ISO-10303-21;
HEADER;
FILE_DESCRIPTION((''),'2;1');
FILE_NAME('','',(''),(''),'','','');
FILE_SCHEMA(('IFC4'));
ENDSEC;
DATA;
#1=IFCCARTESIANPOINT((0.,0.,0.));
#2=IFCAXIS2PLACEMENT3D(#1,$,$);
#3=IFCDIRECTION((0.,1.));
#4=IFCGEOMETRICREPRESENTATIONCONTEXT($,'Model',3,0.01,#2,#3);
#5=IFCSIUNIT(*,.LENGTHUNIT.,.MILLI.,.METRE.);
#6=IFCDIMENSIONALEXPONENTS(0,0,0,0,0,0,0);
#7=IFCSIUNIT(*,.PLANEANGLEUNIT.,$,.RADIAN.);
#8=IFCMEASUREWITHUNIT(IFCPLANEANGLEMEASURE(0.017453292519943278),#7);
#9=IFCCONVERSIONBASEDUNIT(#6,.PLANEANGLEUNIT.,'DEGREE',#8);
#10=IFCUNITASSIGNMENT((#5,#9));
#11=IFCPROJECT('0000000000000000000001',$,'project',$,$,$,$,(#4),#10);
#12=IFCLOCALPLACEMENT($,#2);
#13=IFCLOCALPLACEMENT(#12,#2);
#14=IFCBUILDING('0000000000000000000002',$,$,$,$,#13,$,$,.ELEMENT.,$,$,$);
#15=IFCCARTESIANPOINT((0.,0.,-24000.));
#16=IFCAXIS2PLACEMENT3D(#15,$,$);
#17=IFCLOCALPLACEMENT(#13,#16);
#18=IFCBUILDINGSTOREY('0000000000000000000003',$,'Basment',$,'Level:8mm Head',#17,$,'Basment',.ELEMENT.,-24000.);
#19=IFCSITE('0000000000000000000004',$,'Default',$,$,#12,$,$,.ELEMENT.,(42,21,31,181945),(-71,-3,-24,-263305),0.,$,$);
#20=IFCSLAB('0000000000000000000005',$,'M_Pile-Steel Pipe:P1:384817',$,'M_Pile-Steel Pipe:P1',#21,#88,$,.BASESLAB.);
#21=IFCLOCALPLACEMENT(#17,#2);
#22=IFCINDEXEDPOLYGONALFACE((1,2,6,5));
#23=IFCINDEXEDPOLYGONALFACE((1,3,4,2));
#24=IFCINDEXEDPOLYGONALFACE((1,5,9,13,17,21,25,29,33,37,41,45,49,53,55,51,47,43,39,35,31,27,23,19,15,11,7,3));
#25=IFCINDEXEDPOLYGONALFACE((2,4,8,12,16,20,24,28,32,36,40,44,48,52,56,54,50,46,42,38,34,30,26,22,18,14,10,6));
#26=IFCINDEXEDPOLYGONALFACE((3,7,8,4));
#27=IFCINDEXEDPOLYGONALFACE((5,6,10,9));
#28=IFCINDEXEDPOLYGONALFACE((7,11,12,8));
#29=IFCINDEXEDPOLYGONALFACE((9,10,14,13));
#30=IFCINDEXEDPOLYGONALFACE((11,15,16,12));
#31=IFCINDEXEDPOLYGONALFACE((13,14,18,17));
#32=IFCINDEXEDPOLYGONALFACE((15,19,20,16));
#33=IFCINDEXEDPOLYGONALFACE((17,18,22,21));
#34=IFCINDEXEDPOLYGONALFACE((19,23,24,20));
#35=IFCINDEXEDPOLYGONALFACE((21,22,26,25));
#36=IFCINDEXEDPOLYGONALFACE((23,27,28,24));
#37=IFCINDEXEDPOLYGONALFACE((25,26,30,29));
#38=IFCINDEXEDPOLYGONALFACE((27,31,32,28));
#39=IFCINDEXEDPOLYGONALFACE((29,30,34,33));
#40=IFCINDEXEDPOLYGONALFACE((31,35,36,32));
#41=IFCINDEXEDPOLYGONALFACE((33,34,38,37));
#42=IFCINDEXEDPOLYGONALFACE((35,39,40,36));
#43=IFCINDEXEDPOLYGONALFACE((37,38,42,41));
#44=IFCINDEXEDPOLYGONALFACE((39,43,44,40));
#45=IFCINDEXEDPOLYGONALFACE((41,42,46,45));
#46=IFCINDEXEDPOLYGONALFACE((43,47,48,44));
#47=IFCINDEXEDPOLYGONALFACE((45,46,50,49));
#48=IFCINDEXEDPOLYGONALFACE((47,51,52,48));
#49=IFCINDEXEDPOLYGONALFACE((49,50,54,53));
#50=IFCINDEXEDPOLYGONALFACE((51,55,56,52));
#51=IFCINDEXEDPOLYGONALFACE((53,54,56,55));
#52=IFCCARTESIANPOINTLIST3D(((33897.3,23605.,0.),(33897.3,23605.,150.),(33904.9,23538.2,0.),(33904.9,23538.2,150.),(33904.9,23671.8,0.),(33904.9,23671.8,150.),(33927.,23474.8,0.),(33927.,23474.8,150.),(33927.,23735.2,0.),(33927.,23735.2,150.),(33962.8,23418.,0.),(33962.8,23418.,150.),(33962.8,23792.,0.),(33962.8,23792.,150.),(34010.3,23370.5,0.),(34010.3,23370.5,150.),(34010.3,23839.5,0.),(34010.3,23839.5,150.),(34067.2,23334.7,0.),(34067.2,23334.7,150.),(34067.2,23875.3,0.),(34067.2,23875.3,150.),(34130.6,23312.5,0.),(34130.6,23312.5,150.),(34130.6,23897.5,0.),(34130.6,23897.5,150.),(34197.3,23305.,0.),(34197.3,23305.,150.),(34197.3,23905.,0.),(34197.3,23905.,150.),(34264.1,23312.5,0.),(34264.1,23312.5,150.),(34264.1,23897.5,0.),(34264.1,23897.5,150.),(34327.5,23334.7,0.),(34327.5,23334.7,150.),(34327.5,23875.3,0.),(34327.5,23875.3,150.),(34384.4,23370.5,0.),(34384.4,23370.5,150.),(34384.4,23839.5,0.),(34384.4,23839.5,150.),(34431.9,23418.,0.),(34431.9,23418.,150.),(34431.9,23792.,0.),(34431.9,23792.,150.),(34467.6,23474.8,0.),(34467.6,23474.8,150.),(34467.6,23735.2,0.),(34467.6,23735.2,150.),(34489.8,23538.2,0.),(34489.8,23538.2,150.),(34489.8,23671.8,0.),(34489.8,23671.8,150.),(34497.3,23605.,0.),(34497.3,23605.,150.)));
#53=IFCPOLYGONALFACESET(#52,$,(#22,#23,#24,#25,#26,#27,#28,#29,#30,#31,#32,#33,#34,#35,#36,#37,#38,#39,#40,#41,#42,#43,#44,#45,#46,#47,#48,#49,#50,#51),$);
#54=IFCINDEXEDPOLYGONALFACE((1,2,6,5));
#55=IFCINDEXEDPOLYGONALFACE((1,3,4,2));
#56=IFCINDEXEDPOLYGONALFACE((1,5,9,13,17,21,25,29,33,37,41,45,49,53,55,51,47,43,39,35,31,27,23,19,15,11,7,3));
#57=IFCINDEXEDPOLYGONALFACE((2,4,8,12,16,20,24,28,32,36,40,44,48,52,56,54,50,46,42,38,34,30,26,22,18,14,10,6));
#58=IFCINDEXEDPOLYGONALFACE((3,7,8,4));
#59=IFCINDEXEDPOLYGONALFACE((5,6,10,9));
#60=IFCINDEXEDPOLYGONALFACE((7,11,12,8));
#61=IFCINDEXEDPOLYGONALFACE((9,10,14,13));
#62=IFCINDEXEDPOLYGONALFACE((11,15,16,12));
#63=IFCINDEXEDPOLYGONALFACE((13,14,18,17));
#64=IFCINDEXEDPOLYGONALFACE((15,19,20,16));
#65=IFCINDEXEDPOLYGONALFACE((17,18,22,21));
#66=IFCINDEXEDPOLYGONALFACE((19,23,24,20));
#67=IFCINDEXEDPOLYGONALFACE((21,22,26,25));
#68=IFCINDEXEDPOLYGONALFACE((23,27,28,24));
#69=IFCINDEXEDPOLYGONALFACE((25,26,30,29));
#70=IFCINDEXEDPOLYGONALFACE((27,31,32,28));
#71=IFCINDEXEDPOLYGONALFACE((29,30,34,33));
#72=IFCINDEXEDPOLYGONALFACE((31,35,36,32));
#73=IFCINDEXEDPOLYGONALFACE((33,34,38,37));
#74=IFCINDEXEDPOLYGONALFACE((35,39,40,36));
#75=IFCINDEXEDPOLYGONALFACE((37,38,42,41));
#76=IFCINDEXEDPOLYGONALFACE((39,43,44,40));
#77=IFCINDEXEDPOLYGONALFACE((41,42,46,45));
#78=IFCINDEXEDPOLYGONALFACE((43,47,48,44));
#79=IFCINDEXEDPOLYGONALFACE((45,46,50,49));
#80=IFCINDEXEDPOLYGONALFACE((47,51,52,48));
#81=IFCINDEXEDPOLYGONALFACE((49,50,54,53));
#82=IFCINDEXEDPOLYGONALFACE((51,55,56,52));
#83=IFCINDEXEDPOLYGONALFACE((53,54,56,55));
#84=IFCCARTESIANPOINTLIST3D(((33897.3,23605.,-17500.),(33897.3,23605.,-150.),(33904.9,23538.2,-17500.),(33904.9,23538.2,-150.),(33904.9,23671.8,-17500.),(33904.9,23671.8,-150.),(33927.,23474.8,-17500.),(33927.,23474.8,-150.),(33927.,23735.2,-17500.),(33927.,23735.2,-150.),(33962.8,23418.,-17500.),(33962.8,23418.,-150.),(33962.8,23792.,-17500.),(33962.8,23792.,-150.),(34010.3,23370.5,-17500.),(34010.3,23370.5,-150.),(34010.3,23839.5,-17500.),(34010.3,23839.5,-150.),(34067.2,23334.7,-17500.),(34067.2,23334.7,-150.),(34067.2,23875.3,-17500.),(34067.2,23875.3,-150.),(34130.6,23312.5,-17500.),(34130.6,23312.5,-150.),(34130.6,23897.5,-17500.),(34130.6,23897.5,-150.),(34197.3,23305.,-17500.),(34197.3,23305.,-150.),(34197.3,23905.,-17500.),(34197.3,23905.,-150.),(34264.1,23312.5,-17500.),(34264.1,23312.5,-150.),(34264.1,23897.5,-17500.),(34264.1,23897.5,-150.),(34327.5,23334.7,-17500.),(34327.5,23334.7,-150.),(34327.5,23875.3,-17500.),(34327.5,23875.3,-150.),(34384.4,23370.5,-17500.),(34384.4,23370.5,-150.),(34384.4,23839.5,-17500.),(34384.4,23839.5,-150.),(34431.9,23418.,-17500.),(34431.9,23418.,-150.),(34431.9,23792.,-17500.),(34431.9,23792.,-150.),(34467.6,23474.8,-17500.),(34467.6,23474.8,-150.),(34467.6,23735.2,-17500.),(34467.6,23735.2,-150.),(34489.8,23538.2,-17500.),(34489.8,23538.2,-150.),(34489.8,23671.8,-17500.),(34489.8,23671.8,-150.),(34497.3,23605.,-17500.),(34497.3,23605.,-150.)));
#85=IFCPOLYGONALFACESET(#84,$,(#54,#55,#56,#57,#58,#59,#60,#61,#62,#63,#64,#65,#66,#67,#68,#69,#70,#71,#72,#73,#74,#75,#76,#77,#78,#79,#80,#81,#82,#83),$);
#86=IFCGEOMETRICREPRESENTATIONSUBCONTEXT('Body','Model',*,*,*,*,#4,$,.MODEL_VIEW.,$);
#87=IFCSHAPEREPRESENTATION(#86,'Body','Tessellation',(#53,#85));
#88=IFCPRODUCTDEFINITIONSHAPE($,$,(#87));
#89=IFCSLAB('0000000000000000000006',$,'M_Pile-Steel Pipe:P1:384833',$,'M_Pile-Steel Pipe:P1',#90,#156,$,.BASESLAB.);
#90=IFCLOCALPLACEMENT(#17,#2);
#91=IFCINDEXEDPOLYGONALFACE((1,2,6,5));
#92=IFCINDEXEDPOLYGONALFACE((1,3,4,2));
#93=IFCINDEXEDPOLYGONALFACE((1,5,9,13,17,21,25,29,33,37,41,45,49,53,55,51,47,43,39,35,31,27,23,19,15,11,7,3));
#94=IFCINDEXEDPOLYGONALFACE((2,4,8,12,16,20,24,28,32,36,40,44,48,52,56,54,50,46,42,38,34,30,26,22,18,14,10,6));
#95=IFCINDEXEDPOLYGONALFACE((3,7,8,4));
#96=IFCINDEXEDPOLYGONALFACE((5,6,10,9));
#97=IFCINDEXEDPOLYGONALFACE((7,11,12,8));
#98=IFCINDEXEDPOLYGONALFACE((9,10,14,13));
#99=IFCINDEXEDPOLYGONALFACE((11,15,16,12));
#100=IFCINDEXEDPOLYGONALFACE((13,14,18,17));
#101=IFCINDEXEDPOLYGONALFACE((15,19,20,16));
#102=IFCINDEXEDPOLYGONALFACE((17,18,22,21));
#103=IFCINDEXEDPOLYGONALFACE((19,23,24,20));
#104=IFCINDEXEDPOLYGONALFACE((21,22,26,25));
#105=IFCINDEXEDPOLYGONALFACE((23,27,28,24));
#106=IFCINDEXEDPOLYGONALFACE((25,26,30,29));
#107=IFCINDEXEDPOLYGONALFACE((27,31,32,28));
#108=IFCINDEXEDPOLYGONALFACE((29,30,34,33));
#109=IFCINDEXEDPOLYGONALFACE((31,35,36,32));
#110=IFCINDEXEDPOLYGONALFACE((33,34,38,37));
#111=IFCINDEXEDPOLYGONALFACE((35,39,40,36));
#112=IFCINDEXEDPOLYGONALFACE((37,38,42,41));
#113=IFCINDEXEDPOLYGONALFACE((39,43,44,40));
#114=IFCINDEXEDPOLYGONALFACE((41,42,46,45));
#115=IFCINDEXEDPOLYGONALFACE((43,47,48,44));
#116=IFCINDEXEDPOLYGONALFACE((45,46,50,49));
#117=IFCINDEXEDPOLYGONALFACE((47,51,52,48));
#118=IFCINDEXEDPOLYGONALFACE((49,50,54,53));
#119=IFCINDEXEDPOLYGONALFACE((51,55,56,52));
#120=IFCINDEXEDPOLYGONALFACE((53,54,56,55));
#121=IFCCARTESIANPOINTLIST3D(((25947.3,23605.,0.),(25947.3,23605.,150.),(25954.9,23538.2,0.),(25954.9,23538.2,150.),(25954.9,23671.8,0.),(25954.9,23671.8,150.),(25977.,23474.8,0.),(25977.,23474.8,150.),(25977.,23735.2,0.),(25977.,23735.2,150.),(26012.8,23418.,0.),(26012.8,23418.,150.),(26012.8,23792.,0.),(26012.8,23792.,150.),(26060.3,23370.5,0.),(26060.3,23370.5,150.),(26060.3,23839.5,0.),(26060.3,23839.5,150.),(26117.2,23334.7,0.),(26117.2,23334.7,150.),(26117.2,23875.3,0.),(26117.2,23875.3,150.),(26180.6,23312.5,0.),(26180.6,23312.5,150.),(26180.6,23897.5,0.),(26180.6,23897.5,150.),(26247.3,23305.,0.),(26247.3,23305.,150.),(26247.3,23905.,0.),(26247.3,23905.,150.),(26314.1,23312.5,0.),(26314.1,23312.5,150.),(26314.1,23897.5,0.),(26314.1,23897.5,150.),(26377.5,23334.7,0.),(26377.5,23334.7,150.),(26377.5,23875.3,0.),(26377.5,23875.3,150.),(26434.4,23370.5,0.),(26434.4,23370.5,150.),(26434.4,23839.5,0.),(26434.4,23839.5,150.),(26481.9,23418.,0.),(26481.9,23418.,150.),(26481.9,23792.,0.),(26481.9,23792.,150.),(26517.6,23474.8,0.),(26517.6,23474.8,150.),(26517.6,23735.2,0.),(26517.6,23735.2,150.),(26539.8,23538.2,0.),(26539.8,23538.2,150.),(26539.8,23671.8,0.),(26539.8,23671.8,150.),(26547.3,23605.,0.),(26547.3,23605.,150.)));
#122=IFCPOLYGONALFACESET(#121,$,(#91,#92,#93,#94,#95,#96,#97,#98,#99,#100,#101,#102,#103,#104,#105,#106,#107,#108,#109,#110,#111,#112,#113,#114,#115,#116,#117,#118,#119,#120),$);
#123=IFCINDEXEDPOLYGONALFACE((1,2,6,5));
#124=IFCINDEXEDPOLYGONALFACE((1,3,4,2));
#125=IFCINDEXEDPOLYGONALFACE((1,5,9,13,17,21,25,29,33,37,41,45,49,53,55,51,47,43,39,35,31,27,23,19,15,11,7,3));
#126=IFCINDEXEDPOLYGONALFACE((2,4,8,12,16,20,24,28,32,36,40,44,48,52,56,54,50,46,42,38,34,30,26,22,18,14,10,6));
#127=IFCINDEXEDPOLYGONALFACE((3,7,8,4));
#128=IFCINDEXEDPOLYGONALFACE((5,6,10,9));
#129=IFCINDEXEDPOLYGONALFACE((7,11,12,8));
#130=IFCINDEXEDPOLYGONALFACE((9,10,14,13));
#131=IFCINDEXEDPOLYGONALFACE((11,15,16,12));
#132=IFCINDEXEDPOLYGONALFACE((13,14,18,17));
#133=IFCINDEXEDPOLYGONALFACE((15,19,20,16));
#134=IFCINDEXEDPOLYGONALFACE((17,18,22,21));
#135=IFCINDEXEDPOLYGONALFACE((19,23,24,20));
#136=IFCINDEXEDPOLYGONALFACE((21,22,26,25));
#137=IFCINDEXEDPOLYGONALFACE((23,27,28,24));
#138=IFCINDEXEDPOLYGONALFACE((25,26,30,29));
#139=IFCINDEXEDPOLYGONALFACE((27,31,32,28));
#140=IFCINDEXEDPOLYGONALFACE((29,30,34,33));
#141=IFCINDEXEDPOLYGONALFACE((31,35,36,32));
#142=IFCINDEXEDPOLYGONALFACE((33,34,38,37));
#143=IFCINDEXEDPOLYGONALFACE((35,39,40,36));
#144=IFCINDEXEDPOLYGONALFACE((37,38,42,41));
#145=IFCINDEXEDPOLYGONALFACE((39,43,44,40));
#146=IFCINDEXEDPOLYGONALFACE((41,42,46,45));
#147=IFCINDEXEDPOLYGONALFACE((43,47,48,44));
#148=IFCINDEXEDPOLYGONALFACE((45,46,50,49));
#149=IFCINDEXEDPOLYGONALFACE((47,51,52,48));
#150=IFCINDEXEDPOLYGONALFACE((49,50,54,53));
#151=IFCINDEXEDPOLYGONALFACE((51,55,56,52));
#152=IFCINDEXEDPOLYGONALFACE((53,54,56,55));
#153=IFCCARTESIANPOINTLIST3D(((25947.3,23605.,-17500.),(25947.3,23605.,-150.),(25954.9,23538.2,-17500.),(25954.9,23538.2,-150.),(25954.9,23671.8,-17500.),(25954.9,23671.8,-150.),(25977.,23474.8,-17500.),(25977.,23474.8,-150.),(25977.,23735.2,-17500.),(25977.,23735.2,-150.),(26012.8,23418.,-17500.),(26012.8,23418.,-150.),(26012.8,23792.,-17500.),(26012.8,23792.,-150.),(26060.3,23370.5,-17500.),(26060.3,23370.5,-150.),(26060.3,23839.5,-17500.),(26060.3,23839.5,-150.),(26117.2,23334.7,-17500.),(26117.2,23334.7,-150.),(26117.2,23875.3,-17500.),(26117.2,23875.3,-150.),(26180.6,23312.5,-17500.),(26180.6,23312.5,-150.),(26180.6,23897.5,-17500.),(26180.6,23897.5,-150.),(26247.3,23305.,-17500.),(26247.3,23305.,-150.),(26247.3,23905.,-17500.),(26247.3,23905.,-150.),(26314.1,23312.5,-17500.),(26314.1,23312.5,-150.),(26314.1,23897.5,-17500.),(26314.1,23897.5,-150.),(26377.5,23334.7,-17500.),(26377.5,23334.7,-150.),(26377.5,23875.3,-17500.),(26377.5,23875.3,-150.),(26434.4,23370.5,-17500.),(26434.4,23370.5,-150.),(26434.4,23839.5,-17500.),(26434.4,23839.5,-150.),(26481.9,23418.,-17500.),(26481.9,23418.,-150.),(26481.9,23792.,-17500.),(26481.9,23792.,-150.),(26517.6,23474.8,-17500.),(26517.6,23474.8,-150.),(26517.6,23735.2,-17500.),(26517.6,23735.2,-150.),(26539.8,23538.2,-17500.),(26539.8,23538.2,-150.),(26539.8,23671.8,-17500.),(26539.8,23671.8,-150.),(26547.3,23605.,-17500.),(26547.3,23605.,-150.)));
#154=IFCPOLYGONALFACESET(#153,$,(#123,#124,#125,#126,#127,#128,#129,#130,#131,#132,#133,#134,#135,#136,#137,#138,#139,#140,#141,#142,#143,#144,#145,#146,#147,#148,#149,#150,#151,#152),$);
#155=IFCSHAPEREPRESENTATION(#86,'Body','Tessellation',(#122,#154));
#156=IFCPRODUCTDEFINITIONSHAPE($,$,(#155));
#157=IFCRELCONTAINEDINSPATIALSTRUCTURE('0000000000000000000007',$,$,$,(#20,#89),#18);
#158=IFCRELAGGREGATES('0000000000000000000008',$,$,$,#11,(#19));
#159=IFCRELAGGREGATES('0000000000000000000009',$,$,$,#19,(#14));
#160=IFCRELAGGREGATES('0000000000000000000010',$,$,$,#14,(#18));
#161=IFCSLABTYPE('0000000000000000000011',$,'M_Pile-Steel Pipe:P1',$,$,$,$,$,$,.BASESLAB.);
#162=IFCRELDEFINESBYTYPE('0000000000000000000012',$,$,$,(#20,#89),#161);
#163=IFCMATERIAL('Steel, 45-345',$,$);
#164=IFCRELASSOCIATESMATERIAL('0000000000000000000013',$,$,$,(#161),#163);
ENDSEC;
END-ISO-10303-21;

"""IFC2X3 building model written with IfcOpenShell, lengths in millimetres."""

from ifc_helpers import new_model, entity, si_unit, converted_unit, direction, frame, origin, origin_2d_with_axis, place, context, subcontext, project, spatial, circle, extrude, material, type_object, element, save


model = new_model("IFC2X3")

# Units and contexts
model_context = context("Model", 3, precision=0.01, world=origin(), true_north=direction((0.0, 1.0)))
body_context = subcontext(model_context, "Body", "Model", "MODEL_VIEW")
ifc_project = project(units=[si_unit("LENGTHUNIT", "METRE", prefix="MILLI"), converted_unit("PLANEANGLEUNIT", "DEGREE", entity("IfcPlaneAngleMeasure", 0.017453292519943278), si_unit("PLANEANGLEUNIT", "RADIAN"), dimensions=[0, 0, 0, 0, 0, 0, 0])], contexts=[model_context])

# Site, building, storey
site_placement = place(None, origin())
site = spatial("IfcSite", under=ifc_project, at=site_placement, Name="Default", CompositionType="ELEMENT", RefLatitude=(42, 21, 31, 181945), RefLongitude=(-71, -3, -24, -263305), RefElevation=0.0)
building_placement = place(site_placement, origin())
building = spatial("IfcBuilding", under=site, at=building_placement, CompositionType="ELEMENT")
storey_placement = place(building_placement, frame((0.0, 0.0, -24000.0)))
storey = spatial("IfcBuildingStorey", under=building, at=storey_placement, Name="Basment", ObjectType="Level:8mm Head", LongName="Basment", CompositionType="ELEMENT", Elevation=-24000.0)

# Slabs
ifc_material_1 = material(Name="Steel, 45-345")
slab_type_1 = type_object("IfcSlabType", Name="M_Pile-Steel Pipe:P1", PredefinedType="BASESLAB", material=ifc_material_1)
slab_1_placement = place(storey_placement, origin())
element("IfcSlab", 1, at=slab_1_placement, inside=storey, type_object=slab_type_1, Name="M_Pile-Steel Pipe:P1:384817", ObjectType="M_Pile-Steel Pipe:P1", PredefinedType="BASESLAB", context=body_context, shape_type="SweptSolid", body=[
    extrude(circle(Radius=300.0, at=origin_2d_with_axis()), frame((34197.3, 23605.0, 0.0), z_axis=(0.0, 0.0, 1.0), x_axis=(0.0, 1.0, 0.0)), (0.0, 0.0, 1.0), 150.0),
    extrude(circle(Radius=300.0, at=origin_2d_with_axis()), frame((34197.3, 23605.0, -17500.0), z_axis=(0.0, 0.0, 1.0), x_axis=(0.0, 1.0, 0.0)), (0.0, 0.0, 1.0), 17350.0),
])
slab_2_placement = place(storey_placement, origin())
element("IfcSlab", 2, at=slab_2_placement, inside=storey, type_object=slab_type_1, Name="M_Pile-Steel Pipe:P1:384833", ObjectType="M_Pile-Steel Pipe:P1", PredefinedType="BASESLAB", context=body_context, shape_type="SweptSolid", body=[
    extrude(circle(Radius=300.0, at=origin_2d_with_axis()), frame((26247.3, 23605.0, 0.0), z_axis=(0.0, 0.0, 1.0), x_axis=(0.0, 1.0, 0.0)), (0.0, 0.0, 1.0), 150.0),
    extrude(circle(Radius=300.0, at=origin_2d_with_axis()), frame((26247.3, 23605.0, -17500.0), z_axis=(0.0, 0.0, 1.0), x_axis=(0.0, 1.0, 0.0)), (0.0, 0.0, 1.0), 17350.0),
])

save(model, "model.ifc")
